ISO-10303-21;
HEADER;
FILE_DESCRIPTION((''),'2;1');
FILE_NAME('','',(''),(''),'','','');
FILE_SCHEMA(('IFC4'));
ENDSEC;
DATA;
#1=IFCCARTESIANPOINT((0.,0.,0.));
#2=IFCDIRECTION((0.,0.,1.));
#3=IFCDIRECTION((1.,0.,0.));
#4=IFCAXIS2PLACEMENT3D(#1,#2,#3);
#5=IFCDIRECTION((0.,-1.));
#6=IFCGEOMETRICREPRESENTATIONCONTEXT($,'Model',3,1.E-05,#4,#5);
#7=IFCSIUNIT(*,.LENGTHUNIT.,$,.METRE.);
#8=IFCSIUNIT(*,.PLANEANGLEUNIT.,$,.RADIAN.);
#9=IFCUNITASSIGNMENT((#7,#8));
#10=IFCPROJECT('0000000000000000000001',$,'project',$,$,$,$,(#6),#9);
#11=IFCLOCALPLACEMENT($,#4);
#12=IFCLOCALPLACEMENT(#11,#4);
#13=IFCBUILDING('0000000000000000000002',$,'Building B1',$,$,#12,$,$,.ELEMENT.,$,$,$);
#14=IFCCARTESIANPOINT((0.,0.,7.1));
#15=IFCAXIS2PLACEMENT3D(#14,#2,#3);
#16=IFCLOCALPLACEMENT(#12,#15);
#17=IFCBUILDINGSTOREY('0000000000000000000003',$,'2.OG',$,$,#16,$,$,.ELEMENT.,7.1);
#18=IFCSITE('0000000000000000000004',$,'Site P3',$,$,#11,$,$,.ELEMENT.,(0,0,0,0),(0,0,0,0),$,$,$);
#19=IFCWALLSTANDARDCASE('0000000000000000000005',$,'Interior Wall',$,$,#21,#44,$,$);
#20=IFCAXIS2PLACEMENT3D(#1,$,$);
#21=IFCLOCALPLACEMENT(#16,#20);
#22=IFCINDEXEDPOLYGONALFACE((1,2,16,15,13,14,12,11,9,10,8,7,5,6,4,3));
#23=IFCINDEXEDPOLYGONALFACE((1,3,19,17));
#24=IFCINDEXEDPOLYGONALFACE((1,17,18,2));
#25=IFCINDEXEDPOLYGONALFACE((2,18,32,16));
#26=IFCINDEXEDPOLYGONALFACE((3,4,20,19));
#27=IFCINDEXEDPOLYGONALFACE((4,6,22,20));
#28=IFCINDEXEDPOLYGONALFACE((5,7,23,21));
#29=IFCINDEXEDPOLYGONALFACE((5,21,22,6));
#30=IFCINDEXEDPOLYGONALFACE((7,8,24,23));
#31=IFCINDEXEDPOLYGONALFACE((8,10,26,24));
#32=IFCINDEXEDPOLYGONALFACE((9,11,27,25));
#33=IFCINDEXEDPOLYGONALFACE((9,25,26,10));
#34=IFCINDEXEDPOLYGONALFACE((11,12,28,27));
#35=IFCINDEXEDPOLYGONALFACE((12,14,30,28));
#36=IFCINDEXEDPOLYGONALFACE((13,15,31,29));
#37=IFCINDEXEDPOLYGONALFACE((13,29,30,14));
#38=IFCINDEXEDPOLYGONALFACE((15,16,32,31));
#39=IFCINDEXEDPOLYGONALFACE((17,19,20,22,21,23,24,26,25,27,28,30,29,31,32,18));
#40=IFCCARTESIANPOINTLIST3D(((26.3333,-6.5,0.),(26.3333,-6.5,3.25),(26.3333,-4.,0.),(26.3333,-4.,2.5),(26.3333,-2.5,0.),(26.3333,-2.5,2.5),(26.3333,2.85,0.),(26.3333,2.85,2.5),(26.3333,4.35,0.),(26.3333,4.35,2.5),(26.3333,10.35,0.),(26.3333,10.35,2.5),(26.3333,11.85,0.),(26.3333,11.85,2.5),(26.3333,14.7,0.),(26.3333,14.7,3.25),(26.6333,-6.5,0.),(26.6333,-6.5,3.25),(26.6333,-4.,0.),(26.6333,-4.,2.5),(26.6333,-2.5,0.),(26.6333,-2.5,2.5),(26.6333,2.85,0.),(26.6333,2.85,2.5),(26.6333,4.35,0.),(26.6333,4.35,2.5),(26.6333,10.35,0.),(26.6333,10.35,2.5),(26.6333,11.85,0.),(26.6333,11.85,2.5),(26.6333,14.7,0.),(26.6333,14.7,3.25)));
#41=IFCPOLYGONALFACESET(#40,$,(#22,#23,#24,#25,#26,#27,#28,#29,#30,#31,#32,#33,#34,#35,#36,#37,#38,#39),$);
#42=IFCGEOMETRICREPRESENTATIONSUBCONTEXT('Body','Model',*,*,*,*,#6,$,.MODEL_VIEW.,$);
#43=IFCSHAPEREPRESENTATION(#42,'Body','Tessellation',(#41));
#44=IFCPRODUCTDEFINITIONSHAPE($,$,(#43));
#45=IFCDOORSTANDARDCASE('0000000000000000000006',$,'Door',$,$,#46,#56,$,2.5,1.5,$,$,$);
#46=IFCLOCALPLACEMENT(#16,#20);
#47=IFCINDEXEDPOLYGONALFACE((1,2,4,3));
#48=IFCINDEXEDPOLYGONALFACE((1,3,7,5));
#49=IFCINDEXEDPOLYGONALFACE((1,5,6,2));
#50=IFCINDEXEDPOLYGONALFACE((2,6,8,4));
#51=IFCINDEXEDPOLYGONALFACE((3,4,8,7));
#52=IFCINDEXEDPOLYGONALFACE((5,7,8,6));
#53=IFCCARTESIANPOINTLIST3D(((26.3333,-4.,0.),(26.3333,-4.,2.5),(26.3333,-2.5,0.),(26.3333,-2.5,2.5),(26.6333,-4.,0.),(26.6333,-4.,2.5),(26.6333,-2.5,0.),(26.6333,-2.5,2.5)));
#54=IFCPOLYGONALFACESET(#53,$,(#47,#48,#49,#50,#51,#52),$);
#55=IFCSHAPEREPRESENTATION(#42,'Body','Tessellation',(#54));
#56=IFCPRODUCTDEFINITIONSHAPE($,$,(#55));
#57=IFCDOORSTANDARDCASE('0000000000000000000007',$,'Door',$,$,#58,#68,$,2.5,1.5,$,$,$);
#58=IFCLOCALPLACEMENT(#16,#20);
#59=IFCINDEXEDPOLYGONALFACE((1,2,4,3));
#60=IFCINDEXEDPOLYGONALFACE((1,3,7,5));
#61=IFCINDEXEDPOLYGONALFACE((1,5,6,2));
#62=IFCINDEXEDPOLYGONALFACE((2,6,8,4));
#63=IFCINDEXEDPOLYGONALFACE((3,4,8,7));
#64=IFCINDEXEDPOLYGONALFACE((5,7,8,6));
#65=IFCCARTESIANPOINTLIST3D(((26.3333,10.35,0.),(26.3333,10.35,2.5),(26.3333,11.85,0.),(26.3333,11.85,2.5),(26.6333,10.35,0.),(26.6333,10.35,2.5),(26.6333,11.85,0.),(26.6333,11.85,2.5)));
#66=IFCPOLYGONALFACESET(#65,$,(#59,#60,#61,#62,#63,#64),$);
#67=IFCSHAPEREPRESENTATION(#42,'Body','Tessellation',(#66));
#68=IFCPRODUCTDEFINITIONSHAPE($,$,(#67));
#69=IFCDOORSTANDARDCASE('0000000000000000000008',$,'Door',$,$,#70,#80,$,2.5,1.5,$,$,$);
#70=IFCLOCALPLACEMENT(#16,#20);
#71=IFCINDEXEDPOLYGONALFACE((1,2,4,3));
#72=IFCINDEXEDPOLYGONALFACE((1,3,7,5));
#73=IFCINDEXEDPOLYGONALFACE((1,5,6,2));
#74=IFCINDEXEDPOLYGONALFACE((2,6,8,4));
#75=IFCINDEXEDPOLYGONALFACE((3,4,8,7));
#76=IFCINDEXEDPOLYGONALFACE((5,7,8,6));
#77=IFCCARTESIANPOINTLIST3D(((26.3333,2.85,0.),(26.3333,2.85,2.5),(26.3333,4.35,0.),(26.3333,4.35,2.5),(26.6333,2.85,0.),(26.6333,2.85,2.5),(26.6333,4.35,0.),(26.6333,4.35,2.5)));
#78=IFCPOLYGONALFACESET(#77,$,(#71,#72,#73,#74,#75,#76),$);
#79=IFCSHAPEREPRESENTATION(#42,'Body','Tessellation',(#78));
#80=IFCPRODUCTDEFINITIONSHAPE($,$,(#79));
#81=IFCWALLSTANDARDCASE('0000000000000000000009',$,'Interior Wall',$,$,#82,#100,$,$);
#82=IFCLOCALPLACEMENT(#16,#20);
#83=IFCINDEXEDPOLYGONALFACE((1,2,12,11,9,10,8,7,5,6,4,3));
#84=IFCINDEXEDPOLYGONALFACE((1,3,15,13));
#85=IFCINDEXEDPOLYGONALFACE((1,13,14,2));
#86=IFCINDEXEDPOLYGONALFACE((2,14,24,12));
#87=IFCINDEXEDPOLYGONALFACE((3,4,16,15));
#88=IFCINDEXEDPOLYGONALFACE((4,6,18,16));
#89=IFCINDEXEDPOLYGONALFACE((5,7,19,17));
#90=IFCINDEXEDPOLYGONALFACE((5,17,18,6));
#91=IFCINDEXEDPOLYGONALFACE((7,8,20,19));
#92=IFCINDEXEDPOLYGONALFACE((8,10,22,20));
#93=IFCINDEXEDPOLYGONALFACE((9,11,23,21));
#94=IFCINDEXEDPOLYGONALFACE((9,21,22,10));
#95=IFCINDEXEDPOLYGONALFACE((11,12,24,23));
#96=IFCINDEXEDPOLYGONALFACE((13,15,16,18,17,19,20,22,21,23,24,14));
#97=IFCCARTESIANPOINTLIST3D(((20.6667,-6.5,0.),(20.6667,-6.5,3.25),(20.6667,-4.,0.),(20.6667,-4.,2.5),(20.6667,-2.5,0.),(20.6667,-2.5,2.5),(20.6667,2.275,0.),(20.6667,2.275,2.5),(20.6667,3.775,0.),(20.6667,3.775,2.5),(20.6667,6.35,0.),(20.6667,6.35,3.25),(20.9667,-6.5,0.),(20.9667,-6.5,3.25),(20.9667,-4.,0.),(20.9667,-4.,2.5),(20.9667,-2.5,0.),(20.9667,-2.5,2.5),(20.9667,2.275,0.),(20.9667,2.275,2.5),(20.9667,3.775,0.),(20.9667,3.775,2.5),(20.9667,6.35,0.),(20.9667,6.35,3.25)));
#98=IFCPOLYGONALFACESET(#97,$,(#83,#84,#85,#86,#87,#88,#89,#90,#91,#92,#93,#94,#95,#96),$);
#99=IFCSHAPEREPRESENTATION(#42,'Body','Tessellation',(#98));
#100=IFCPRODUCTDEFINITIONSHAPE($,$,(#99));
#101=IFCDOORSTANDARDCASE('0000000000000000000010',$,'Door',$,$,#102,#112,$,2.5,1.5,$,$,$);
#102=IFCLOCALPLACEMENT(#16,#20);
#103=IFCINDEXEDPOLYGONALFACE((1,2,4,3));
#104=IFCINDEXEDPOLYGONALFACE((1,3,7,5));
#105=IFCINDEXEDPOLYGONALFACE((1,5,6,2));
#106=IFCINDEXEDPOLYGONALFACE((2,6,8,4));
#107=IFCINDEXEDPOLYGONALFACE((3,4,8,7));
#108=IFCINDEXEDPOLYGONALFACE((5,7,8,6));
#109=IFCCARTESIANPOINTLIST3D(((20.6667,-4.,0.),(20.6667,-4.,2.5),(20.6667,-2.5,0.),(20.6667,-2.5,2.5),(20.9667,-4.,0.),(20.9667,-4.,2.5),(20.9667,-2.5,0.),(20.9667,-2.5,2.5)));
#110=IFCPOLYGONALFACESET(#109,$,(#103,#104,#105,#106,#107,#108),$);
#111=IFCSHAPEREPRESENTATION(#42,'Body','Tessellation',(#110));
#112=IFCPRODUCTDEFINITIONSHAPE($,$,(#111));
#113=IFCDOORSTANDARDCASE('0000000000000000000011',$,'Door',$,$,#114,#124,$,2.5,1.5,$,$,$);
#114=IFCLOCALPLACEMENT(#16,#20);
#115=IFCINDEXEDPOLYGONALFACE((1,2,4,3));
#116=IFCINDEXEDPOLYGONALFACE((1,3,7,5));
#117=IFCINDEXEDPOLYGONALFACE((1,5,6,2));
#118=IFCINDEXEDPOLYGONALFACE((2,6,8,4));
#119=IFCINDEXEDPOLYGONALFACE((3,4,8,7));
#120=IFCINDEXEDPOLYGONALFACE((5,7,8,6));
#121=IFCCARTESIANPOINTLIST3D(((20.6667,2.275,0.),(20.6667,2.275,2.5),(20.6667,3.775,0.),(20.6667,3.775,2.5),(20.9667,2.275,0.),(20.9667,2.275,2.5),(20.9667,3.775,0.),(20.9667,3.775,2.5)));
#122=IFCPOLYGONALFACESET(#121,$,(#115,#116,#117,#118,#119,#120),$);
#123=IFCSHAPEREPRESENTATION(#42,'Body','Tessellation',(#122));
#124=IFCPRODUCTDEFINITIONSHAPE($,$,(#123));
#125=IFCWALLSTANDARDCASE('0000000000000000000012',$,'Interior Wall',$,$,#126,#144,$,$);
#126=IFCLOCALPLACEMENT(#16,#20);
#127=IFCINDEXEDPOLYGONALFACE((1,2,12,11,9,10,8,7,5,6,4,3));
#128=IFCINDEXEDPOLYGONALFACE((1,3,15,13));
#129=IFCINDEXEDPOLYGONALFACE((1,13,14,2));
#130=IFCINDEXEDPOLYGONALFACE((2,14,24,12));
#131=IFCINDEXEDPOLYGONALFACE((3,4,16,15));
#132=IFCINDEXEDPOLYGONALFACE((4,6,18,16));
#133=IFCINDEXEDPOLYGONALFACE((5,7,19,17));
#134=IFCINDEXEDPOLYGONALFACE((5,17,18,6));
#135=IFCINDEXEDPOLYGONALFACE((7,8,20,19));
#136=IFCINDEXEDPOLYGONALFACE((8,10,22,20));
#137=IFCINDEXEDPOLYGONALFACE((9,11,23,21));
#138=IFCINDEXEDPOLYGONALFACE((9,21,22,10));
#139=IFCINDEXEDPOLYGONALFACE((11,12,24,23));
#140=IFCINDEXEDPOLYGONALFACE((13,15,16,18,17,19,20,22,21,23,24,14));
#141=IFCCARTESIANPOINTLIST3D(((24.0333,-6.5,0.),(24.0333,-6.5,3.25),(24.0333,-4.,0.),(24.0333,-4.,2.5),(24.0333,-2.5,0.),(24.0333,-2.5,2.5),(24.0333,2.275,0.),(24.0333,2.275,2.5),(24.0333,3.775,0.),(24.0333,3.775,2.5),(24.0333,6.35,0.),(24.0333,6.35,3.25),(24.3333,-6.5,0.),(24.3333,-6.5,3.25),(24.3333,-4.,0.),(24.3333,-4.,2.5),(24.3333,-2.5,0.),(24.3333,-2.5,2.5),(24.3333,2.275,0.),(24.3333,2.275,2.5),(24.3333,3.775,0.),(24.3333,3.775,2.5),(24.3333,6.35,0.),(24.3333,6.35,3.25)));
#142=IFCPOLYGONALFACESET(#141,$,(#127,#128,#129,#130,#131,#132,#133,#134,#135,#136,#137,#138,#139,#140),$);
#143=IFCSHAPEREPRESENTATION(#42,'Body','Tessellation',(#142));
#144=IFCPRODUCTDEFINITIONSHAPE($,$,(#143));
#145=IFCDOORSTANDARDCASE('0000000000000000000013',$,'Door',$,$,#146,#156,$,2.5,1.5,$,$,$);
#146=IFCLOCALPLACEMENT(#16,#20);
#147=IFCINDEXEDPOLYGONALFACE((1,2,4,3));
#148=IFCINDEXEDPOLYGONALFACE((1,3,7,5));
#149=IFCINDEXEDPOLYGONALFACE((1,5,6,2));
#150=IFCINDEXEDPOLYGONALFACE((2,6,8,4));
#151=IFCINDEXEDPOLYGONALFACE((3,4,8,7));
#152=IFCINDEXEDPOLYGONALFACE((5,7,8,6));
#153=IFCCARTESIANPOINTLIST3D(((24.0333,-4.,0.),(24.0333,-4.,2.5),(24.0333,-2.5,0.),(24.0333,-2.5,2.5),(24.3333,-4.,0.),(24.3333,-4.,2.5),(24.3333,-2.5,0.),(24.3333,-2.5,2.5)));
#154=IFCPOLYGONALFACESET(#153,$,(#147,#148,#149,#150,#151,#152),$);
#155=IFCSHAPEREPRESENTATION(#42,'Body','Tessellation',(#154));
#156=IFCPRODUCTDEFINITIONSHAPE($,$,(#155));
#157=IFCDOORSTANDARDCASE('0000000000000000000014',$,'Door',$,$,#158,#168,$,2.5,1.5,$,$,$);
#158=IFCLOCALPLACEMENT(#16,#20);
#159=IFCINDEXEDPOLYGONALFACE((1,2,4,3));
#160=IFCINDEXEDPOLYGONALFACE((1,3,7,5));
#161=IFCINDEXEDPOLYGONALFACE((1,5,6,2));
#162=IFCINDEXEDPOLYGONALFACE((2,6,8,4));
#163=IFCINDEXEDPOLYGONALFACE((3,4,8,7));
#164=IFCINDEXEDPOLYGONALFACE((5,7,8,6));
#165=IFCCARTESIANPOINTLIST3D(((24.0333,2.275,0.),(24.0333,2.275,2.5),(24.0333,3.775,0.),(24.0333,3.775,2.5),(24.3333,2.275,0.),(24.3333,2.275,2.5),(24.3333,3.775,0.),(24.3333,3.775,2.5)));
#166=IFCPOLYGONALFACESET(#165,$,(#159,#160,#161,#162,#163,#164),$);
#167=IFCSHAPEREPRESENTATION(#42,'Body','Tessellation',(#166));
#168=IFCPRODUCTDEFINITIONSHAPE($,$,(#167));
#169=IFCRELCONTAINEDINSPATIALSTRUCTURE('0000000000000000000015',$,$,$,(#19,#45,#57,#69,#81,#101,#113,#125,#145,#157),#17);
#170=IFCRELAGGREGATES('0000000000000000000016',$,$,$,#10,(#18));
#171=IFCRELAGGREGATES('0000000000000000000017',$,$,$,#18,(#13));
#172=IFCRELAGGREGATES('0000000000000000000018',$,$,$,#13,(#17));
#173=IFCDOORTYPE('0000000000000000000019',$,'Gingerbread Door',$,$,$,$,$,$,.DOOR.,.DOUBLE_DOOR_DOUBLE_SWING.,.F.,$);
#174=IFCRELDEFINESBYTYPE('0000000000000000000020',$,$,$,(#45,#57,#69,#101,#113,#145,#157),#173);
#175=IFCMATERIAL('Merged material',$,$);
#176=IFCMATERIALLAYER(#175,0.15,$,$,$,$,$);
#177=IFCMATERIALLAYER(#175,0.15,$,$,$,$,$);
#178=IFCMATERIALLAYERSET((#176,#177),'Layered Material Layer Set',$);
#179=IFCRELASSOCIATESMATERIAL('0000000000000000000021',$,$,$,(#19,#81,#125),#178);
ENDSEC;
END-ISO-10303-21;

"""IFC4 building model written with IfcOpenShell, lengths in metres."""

from ifc_helpers import new_model, si_unit, direction, frame, origin_with_axes, place, context, subcontext, project, spatial, polyline, outline, extrude, source, transform, mapped, material, layer, layer_set, layer_usage, type_object, element, fill, save


model = new_model("IFC4")

# Units and contexts
model_context = context("Model", 3, precision=1e-05, world=origin_with_axes(), true_north=direction((0.0, -1.0)))
body_context = subcontext(model_context, "Body", "Model", "MODEL_VIEW")
ifc_project = project(units=[si_unit("LENGTHUNIT", "METRE"), si_unit("PLANEANGLEUNIT", "RADIAN")], contexts=[model_context])

# Site, building, storey
site_placement = place(None, origin_with_axes())
site = spatial("IfcSite", under=ifc_project, at=site_placement, Name="Site P3", CompositionType="ELEMENT", RefLatitude=(0, 0, 0, 0), RefLongitude=(0, 0, 0, 0))
building_placement = place(site_placement, origin_with_axes())
building = spatial("IfcBuilding", under=site, at=building_placement, Name="Building B1", CompositionType="ELEMENT")
storey_placement = place(building_placement, frame((0.0, 0.0, 7.1), z_axis=(0.0, 0.0, 1.0), x_axis=(1.0, 0.0, 0.0)))
storey = spatial("IfcBuildingStorey", under=building, at=storey_placement, Name="2.OG", CompositionType="ELEMENT", Elevation=7.1)

# Shared definitions
ifc_material = material(Name="Merged material")

# Walls, openings, doors
ifc_layer_1 = layer(ifc_material, 0.15)
ifc_layer_2 = layer(ifc_material, 0.15)
ifc_layer_set_1 = layer_set([ifc_layer_1, ifc_layer_2], Name="Layered Material Layer Set")
ifc_layer_usage_1 = layer_usage(ifc_layer_set_1, "AXIS2", "POSITIVE", -0.15)
wall_1_placement = place(storey_placement, frame((26.4833, 14.7, 0.0), z_axis=(0.0, 0.0, 1.0), x_axis=(0.0, -1.0, 0.0)))
wall_1 = element("IfcWallStandardCase", 1, at=wall_1_placement, inside=storey, material=ifc_layer_usage_1, Name="Interior Wall", context=body_context, shape_type="SweptSolid", body=[
    extrude(outline(polyline([(0.0, 0.15), (21.2, 0.15), (21.2, -0.15), (0.0, -0.15), (0.0, 0.15)])), origin_with_axes(), (0.0, 0.0, 1.0), 3.25),
])
opening_1_placement = place(wall_1_placement, frame((17.2, 0.0, 0.0), z_axis=(0.0, 0.0, 1.0), x_axis=(1.0, 0.0, 0.0)))
opening_1 = element("IfcOpeningStandardCase", 2, at=opening_1_placement, cuts=wall_1, context=body_context, shape_type="SweptSolid", body=[
    extrude(outline(polyline([(0.0, 0.0), (0.0, 1.5), (2.5, 1.5), (2.5, 0.0), (0.0, 0.0)])), frame((0.0, -0.15, 0.0), z_axis=(0.0, 1.0, 0.0), x_axis=(0.0, 0.0, 1.0)), (0.0, 0.0, 1.0), 0.3),
])
opening_2_placement = place(wall_1_placement, frame((2.85, 0.0, 0.0), z_axis=(0.0, 0.0, 1.0), x_axis=(1.0, 0.0, 0.0)))
opening_2 = element("IfcOpeningStandardCase", 3, at=opening_2_placement, cuts=wall_1, context=body_context, shape_type="SweptSolid", body=[
    extrude(outline(polyline([(0.0, 0.0), (0.0, 1.5), (2.5, 1.5), (2.5, 0.0), (0.0, 0.0)])), frame((0.0, -0.15, 0.0), z_axis=(0.0, 1.0, 0.0), x_axis=(0.0, 0.0, 1.0)), (0.0, 0.0, 1.0), 0.3),
])
opening_3_placement = place(wall_1_placement, frame((10.35, 0.0, 0.0), z_axis=(0.0, 0.0, 1.0), x_axis=(1.0, 0.0, 0.0)))
opening_3 = element("IfcOpeningStandardCase", 4, at=opening_3_placement, cuts=wall_1, context=body_context, shape_type="SweptSolid", body=[
    extrude(outline(polyline([(0.0, 0.0), (0.0, 1.5), (2.5, 1.5), (2.5, 0.0), (0.0, 0.0)])), frame((0.0, -0.15, 0.0), z_axis=(0.0, 1.0, 0.0), x_axis=(0.0, 0.0, 1.0)), (0.0, 0.0, 1.0), 0.3),
])
door_type = type_object("IfcDoorType", Name="Gingerbread Door", OperationType="DOUBLE_DOOR_DOUBLE_SWING", ParameterTakesPrecedence=False, PredefinedType="DOOR")
shared_shape_1 = source(origin_with_axes(), body_context, "Body", "SweptSolid", [
    extrude(outline(polyline([(0.0, 0.0), (0.0, 1.5), (2.5, 1.5), (2.5, 0.0), (0.0, 0.0)])), frame((0.0, -0.15, 0.0), z_axis=(0.0, 1.0, 0.0), x_axis=(0.0, 0.0, 1.0)), (0.0, 0.0, 1.0), 0.3),
])
door_1_placement = place(opening_1_placement, origin_with_axes())
door_1 = element("IfcDoorStandardCase", 5, at=door_1_placement, inside=storey, type_object=door_type, Name="Door", OverallHeight=2.5, OverallWidth=1.5, context=body_context, shape_type="MappedRepresentation", body=[
    mapped(shared_shape_1, transform((0.0, 0.0, 0.0))),
])
fill(opening_1, door_1)
door_2_placement = place(opening_2_placement, origin_with_axes())
door_2 = element("IfcDoorStandardCase", 6, at=door_2_placement, inside=storey, type_object=door_type, Name="Door", OverallHeight=2.5, OverallWidth=1.5, context=body_context, shape_type="MappedRepresentation", body=[
    mapped(shared_shape_1, transform((0.0, 0.0, 0.0))),
])
fill(opening_2, door_2)
door_3_placement = place(opening_3_placement, origin_with_axes())
door_3 = element("IfcDoorStandardCase", 7, at=door_3_placement, inside=storey, type_object=door_type, Name="Door", OverallHeight=2.5, OverallWidth=1.5, context=body_context, shape_type="MappedRepresentation", body=[
    mapped(shared_shape_1, transform((0.0, 0.0, 0.0))),
])
fill(opening_3, door_3)
wall_2_placement = place(storey_placement, frame((20.8167, 6.35, 0.0), z_axis=(0.0, 0.0, 1.0), x_axis=(0.0, -1.0, 0.0)))
wall_2 = element("IfcWallStandardCase", 8, at=wall_2_placement, inside=storey, material=ifc_layer_usage_1, Name="Interior Wall", context=body_context, shape_type="SweptSolid", body=[
    extrude(outline(polyline([(0.0, 0.15), (12.85, 0.15), (12.85, -0.15), (0.0, -0.15), (0.0, 0.15)])), origin_with_axes(), (0.0, 0.0, 1.0), 3.25),
])
opening_4_placement = place(wall_2_placement, frame((8.85, 0.0, 0.0), z_axis=(0.0, 0.0, 1.0), x_axis=(1.0, 0.0, 0.0)))
opening_4 = element("IfcOpeningStandardCase", 9, at=opening_4_placement, cuts=wall_2, context=body_context, shape_type="SweptSolid", body=[
    extrude(outline(polyline([(0.0, 0.0), (0.0, 1.5), (2.5, 1.5), (2.5, 0.0), (0.0, 0.0)])), frame((0.0, -0.15, 0.0), z_axis=(0.0, 1.0, 0.0), x_axis=(0.0, 0.0, 1.0)), (0.0, 0.0, 1.0), 0.3),
])
opening_5_placement = place(wall_2_placement, frame((2.575, 0.0, 0.0), z_axis=(0.0, 0.0, 1.0), x_axis=(1.0, 0.0, 0.0)))
opening_5 = element("IfcOpeningStandardCase", 10, at=opening_5_placement, cuts=wall_2, context=body_context, shape_type="SweptSolid", body=[
    extrude(outline(polyline([(0.0, 0.0), (0.0, 1.5), (2.5, 1.5), (2.5, 0.0), (0.0, 0.0)])), frame((0.0, -0.15, 0.0), z_axis=(0.0, 1.0, 0.0), x_axis=(0.0, 0.0, 1.0)), (0.0, 0.0, 1.0), 0.3),
])
door_4_placement = place(opening_4_placement, origin_with_axes())
door_4 = element("IfcDoorStandardCase", 11, at=door_4_placement, inside=storey, type_object=door_type, Name="Door", OverallHeight=2.5, OverallWidth=1.5, context=body_context, shape_type="MappedRepresentation", body=[
    mapped(shared_shape_1, transform((0.0, 0.0, 0.0))),
])
fill(opening_4, door_4)
door_5_placement = place(opening_5_placement, origin_with_axes())
door_5 = element("IfcDoorStandardCase", 12, at=door_5_placement, inside=storey, type_object=door_type, Name="Door", OverallHeight=2.5, OverallWidth=1.5, context=body_context, shape_type="MappedRepresentation", body=[
    mapped(shared_shape_1, transform((0.0, 0.0, 0.0))),
])
fill(opening_5, door_5)
wall_3_placement = place(storey_placement, frame((24.1833, 6.35, 0.0), z_axis=(0.0, 0.0, 1.0), x_axis=(0.0, -1.0, 0.0)))
wall_3 = element("IfcWallStandardCase", 13, at=wall_3_placement, inside=storey, material=ifc_layer_usage_1, Name="Interior Wall", context=body_context, shape_type="SweptSolid", body=[
    extrude(outline(polyline([(0.0, 0.15), (12.85, 0.15), (12.85, -0.15), (0.0, -0.15), (0.0, 0.15)])), origin_with_axes(), (0.0, 0.0, 1.0), 3.25),
])
opening_6_placement = place(wall_3_placement, frame((8.85, 0.0, 0.0), z_axis=(0.0, 0.0, 1.0), x_axis=(1.0, 0.0, 0.0)))
opening_6 = element("IfcOpeningStandardCase", 14, at=opening_6_placement, cuts=wall_3, context=body_context, shape_type="SweptSolid", body=[
    extrude(outline(polyline([(0.0, 0.0), (0.0, 1.5), (2.5, 1.5), (2.5, 0.0), (0.0, 0.0)])), frame((0.0, -0.15, 0.0), z_axis=(0.0, 1.0, 0.0), x_axis=(0.0, 0.0, 1.0)), (0.0, 0.0, 1.0), 0.3),
])
opening_7_placement = place(wall_3_placement, frame((2.575, 0.0, 0.0), z_axis=(0.0, 0.0, 1.0), x_axis=(1.0, 0.0, 0.0)))
opening_7 = element("IfcOpeningStandardCase", 15, at=opening_7_placement, cuts=wall_3, context=body_context, shape_type="SweptSolid", body=[
    extrude(outline(polyline([(0.0, 0.0), (0.0, 1.5), (2.5, 1.5), (2.5, 0.0), (0.0, 0.0)])), frame((0.0, -0.15, 0.0), z_axis=(0.0, 1.0, 0.0), x_axis=(0.0, 0.0, 1.0)), (0.0, 0.0, 1.0), 0.3),
])
door_6_placement = place(opening_6_placement, origin_with_axes())
door_6 = element("IfcDoorStandardCase", 16, at=door_6_placement, inside=storey, type_object=door_type, Name="Door", OverallHeight=2.5, OverallWidth=1.5, context=body_context, shape_type="MappedRepresentation", body=[
    mapped(shared_shape_1, transform((0.0, 0.0, 0.0))),
])
fill(opening_6, door_6)
door_7_placement = place(opening_7_placement, origin_with_axes())
door_7 = element("IfcDoorStandardCase", 17, at=door_7_placement, inside=storey, type_object=door_type, Name="Door", OverallHeight=2.5, OverallWidth=1.5, context=body_context, shape_type="MappedRepresentation", body=[
    mapped(shared_shape_1, transform((0.0, 0.0, 0.0))),
])
fill(opening_7, door_7)

save(model, "model.ifc")
